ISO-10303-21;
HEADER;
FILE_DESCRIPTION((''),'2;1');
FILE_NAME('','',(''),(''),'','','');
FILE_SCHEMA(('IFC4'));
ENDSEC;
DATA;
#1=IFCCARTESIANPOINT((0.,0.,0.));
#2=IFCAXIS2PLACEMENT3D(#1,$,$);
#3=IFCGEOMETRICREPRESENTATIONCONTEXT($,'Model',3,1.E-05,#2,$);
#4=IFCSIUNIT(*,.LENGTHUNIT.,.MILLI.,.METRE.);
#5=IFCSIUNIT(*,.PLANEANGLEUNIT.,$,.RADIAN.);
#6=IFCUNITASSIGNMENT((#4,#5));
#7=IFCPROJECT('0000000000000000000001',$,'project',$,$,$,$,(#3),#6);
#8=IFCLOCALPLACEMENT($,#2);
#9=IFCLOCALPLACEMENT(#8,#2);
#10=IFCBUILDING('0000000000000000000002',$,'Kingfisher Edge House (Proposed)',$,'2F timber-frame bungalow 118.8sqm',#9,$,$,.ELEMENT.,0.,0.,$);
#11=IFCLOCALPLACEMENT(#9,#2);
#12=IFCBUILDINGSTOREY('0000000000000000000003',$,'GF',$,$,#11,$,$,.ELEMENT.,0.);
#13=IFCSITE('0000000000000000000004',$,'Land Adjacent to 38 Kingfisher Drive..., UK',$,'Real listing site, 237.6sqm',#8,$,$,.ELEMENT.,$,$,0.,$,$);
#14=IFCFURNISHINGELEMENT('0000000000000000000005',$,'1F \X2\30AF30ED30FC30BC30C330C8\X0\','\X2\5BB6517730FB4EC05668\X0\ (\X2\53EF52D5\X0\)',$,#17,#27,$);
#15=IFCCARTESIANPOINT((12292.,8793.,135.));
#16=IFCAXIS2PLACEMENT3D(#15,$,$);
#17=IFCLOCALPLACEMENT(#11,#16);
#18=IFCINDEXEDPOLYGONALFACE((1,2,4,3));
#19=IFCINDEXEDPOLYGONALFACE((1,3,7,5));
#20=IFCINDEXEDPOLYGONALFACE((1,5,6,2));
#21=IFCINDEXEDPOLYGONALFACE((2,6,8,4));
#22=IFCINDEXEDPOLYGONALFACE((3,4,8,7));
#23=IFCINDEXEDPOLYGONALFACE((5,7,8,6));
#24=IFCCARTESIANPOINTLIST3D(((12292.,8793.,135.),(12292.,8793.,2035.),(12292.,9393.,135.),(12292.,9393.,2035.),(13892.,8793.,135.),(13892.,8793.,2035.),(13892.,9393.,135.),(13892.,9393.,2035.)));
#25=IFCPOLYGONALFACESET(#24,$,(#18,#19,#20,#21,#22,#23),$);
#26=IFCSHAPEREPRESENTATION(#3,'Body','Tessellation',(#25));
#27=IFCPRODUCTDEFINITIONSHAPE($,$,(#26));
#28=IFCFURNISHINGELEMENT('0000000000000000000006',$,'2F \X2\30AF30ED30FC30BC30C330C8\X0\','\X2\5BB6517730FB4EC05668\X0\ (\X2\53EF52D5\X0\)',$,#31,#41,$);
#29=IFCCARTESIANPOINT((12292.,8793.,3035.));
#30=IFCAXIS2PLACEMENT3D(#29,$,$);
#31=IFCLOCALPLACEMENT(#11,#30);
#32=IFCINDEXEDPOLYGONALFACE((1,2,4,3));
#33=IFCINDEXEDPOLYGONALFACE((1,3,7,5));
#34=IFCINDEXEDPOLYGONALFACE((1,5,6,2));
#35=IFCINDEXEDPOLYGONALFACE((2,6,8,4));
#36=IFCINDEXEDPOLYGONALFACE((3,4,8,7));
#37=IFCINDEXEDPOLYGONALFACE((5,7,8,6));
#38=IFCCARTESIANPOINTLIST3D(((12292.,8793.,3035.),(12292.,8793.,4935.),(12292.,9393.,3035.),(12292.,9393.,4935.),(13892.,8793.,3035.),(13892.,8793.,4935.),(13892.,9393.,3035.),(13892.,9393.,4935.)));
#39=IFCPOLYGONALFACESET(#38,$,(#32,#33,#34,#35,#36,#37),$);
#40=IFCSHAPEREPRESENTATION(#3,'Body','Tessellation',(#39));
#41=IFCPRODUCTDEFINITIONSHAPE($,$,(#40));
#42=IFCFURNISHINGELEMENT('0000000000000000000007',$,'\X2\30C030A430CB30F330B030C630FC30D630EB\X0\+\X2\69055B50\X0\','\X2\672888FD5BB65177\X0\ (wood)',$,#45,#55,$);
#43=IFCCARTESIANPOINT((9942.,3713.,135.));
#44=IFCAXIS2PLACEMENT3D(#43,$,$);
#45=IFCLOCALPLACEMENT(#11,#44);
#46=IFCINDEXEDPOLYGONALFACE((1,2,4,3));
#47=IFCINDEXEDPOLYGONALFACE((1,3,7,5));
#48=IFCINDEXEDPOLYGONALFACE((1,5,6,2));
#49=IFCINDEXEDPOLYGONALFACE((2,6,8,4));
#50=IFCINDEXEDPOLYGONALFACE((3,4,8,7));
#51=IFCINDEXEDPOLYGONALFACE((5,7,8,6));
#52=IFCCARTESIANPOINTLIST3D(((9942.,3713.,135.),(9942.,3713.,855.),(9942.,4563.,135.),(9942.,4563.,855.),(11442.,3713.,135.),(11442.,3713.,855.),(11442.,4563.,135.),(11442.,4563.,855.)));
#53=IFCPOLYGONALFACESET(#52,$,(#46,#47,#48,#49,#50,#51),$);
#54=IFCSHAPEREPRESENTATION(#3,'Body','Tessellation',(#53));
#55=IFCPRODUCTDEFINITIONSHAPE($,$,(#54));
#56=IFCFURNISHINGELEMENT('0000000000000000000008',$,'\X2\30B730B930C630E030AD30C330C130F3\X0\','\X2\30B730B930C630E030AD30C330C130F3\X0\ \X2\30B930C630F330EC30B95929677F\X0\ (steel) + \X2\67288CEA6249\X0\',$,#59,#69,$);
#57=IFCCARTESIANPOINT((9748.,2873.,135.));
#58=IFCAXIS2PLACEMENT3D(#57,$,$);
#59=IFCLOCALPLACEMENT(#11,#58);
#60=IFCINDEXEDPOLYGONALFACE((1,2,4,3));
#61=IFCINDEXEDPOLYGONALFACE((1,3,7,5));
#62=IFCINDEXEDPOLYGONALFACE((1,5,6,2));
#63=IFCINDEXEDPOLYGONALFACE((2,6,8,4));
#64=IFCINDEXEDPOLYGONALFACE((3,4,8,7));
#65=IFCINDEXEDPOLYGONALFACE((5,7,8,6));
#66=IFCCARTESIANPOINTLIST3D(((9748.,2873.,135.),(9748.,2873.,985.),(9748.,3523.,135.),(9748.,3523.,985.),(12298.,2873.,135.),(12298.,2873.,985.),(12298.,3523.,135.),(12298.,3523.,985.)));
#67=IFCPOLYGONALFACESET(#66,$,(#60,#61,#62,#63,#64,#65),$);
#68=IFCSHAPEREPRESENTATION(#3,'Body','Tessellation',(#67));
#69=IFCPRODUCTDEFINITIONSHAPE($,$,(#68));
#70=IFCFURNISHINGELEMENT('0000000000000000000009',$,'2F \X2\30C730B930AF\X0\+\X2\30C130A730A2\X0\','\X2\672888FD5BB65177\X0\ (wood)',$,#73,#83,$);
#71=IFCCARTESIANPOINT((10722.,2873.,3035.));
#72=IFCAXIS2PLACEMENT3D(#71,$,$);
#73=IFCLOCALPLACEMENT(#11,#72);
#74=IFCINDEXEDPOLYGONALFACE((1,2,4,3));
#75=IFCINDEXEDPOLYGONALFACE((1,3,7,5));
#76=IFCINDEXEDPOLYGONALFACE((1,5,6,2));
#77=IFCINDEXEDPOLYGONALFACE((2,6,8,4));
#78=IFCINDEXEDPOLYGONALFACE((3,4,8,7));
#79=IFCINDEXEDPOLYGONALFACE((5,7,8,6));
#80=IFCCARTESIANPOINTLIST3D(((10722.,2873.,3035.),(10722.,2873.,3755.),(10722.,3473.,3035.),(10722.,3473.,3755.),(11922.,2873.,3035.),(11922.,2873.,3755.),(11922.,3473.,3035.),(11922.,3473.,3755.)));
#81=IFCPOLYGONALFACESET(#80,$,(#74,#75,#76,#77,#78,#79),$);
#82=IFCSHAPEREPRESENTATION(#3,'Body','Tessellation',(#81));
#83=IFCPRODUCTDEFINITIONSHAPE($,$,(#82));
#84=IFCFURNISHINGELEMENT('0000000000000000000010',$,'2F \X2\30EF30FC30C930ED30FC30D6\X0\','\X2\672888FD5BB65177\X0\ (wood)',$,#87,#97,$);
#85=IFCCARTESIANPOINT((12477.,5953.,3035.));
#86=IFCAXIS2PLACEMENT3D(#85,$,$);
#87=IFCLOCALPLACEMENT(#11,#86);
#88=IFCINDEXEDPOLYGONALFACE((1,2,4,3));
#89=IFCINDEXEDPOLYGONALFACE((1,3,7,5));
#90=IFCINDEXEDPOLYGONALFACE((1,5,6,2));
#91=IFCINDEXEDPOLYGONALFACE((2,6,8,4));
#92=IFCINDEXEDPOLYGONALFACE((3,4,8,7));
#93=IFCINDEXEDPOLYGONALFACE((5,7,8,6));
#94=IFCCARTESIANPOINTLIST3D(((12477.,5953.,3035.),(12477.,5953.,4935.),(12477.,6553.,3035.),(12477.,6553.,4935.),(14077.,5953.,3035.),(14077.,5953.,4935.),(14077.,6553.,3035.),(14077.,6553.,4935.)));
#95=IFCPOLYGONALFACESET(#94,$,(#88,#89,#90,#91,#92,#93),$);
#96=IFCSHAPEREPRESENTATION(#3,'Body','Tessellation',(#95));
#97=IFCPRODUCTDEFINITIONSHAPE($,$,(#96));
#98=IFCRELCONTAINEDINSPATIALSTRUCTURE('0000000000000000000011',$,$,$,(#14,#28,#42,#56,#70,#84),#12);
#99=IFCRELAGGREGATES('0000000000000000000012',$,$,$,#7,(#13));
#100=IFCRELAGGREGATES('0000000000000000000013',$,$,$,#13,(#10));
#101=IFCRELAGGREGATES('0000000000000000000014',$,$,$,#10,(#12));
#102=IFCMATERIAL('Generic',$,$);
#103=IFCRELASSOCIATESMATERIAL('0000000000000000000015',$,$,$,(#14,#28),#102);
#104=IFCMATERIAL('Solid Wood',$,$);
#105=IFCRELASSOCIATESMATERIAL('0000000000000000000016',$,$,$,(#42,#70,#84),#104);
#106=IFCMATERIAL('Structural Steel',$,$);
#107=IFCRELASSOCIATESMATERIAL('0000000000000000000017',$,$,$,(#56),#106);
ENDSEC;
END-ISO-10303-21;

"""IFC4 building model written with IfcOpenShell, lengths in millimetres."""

from ifc_helpers import new_model, si_unit, frame, frame_2d, origin, place, context, project, spatial, rectangle, extrude, material, element, save


model = new_model("IFC4")

# Units and contexts
model_context = context("Model", 3, precision=1e-05, world=origin())
ifc_project = project(units=[si_unit("LENGTHUNIT", "METRE", prefix="MILLI"), si_unit("PLANEANGLEUNIT", "RADIAN")], contexts=[model_context])

# Site, building, storey
site_placement = place(None, origin())
site = spatial("IfcSite", under=ifc_project, at=site_placement, Name="Land Adjacent to 38 Kingfisher Drive..., UK", ObjectType="Real listing site, 237.6sqm", CompositionType="ELEMENT", RefElevation=0.0)
building_placement = place(site_placement, origin())
building = spatial("IfcBuilding", under=site, at=building_placement, Name="Kingfisher Edge House (Proposed)", ObjectType="2F timber-frame bungalow 118.8sqm", CompositionType="ELEMENT", ElevationOfRefHeight=0.0, ElevationOfTerrain=0.0)
storey_placement = place(building_placement, origin())
storey = spatial("IfcBuildingStorey", under=building, at=storey_placement, Name="GF", CompositionType="ELEMENT", Elevation=0.0)

# Shared definitions
ifc_material_1 = material(Name="Solid Wood")

# Shared definitions
ifc_material_2 = material(Name="Generic")

# Furnishing elements
furnishing_1_placement = place(storey_placement, frame((12292.0, 8793.0, 135.0)))
element("IfcFurnishingElement", 1, at=furnishing_1_placement, inside=storey, material=ifc_material_2, Name="1F クローゼット", Description="家具・什器 (可動)", context=model_context, shape_type="SweptSolid", body=[
    extrude(rectangle(XDim=1600.0, YDim=600.0, at=frame_2d((800.0, 300.0))), frame((12292.0, 8793.0, 135.0)), (0.0, 0.0, 1.0), 1900.0),
])
furnishing_2_placement = place(storey_placement, frame((12292.0, 8793.0, 3035.0)))
element("IfcFurnishingElement", 2, at=furnishing_2_placement, inside=storey, material=ifc_material_2, Name="2F クローゼット", Description="家具・什器 (可動)", context=model_context, shape_type="SweptSolid", body=[
    extrude(rectangle(XDim=1600.0, YDim=600.0, at=frame_2d((800.0, 300.0))), frame((12292.0, 8793.0, 3035.0)), (0.0, 0.0, 1.0), 1900.0),
])
furnishing_3_placement = place(storey_placement, frame((9942.0, 3713.0, 135.0)))
element("IfcFurnishingElement", 3, at=furnishing_3_placement, inside=storey, material=ifc_material_1, Name="ダイニングテーブル+椅子", Description="木製家具 (wood)", context=model_context, shape_type="SweptSolid", body=[
    extrude(rectangle(XDim=1500.0, YDim=850.0, at=frame_2d((750.0, 425.0))), frame((9942.0, 3713.0, 135.0)), (0.0, 0.0, 1.0), 720.0),
])
ifc_material_3 = material(Name="Structural Steel")
furnishing_4_placement = place(storey_placement, frame((9748.0, 2873.0, 135.0)))
element("IfcFurnishingElement", 4, at=furnishing_4_placement, inside=storey, material=ifc_material_3, Name="システムキッチン", Description="システムキッチン ステンレス天板 (steel) + 木質扉", context=model_context, shape_type="SweptSolid", body=[
    extrude(rectangle(XDim=2550.0, YDim=650.0, at=frame_2d((1275.0, 325.0))), frame((9748.0, 2873.0, 135.0)), (0.0, 0.0, 1.0), 850.0),
])
furnishing_5_placement = place(storey_placement, frame((10722.0, 2873.0, 3035.0)))
element("IfcFurnishingElement", 5, at=furnishing_5_placement, inside=storey, material=ifc_material_1, Name="2F デスク+チェア", Description="木製家具 (wood)", context=model_context, shape_type="SweptSolid", body=[
    extrude(rectangle(XDim=1200.0, YDim=600.0, at=frame_2d((600.0, 300.0))), frame((10722.0, 2873.0, 3035.0)), (0.0, 0.0, 1.0), 720.0),
])
furnishing_6_placement = place(storey_placement, frame((12477.0, 5953.0, 3035.0)))
element("IfcFurnishingElement", 6, at=furnishing_6_placement, inside=storey, material=ifc_material_1, Name="2F ワードローブ", Description="木製家具 (wood)", context=model_context, shape_type="SweptSolid", body=[
    extrude(rectangle(XDim=1600.0, YDim=600.0, at=frame_2d((800.0, 300.0))), frame((12477.0, 5953.0, 3035.0)), (0.0, 0.0, 1.0), 1900.0),
])

save(model, "model.ifc")
